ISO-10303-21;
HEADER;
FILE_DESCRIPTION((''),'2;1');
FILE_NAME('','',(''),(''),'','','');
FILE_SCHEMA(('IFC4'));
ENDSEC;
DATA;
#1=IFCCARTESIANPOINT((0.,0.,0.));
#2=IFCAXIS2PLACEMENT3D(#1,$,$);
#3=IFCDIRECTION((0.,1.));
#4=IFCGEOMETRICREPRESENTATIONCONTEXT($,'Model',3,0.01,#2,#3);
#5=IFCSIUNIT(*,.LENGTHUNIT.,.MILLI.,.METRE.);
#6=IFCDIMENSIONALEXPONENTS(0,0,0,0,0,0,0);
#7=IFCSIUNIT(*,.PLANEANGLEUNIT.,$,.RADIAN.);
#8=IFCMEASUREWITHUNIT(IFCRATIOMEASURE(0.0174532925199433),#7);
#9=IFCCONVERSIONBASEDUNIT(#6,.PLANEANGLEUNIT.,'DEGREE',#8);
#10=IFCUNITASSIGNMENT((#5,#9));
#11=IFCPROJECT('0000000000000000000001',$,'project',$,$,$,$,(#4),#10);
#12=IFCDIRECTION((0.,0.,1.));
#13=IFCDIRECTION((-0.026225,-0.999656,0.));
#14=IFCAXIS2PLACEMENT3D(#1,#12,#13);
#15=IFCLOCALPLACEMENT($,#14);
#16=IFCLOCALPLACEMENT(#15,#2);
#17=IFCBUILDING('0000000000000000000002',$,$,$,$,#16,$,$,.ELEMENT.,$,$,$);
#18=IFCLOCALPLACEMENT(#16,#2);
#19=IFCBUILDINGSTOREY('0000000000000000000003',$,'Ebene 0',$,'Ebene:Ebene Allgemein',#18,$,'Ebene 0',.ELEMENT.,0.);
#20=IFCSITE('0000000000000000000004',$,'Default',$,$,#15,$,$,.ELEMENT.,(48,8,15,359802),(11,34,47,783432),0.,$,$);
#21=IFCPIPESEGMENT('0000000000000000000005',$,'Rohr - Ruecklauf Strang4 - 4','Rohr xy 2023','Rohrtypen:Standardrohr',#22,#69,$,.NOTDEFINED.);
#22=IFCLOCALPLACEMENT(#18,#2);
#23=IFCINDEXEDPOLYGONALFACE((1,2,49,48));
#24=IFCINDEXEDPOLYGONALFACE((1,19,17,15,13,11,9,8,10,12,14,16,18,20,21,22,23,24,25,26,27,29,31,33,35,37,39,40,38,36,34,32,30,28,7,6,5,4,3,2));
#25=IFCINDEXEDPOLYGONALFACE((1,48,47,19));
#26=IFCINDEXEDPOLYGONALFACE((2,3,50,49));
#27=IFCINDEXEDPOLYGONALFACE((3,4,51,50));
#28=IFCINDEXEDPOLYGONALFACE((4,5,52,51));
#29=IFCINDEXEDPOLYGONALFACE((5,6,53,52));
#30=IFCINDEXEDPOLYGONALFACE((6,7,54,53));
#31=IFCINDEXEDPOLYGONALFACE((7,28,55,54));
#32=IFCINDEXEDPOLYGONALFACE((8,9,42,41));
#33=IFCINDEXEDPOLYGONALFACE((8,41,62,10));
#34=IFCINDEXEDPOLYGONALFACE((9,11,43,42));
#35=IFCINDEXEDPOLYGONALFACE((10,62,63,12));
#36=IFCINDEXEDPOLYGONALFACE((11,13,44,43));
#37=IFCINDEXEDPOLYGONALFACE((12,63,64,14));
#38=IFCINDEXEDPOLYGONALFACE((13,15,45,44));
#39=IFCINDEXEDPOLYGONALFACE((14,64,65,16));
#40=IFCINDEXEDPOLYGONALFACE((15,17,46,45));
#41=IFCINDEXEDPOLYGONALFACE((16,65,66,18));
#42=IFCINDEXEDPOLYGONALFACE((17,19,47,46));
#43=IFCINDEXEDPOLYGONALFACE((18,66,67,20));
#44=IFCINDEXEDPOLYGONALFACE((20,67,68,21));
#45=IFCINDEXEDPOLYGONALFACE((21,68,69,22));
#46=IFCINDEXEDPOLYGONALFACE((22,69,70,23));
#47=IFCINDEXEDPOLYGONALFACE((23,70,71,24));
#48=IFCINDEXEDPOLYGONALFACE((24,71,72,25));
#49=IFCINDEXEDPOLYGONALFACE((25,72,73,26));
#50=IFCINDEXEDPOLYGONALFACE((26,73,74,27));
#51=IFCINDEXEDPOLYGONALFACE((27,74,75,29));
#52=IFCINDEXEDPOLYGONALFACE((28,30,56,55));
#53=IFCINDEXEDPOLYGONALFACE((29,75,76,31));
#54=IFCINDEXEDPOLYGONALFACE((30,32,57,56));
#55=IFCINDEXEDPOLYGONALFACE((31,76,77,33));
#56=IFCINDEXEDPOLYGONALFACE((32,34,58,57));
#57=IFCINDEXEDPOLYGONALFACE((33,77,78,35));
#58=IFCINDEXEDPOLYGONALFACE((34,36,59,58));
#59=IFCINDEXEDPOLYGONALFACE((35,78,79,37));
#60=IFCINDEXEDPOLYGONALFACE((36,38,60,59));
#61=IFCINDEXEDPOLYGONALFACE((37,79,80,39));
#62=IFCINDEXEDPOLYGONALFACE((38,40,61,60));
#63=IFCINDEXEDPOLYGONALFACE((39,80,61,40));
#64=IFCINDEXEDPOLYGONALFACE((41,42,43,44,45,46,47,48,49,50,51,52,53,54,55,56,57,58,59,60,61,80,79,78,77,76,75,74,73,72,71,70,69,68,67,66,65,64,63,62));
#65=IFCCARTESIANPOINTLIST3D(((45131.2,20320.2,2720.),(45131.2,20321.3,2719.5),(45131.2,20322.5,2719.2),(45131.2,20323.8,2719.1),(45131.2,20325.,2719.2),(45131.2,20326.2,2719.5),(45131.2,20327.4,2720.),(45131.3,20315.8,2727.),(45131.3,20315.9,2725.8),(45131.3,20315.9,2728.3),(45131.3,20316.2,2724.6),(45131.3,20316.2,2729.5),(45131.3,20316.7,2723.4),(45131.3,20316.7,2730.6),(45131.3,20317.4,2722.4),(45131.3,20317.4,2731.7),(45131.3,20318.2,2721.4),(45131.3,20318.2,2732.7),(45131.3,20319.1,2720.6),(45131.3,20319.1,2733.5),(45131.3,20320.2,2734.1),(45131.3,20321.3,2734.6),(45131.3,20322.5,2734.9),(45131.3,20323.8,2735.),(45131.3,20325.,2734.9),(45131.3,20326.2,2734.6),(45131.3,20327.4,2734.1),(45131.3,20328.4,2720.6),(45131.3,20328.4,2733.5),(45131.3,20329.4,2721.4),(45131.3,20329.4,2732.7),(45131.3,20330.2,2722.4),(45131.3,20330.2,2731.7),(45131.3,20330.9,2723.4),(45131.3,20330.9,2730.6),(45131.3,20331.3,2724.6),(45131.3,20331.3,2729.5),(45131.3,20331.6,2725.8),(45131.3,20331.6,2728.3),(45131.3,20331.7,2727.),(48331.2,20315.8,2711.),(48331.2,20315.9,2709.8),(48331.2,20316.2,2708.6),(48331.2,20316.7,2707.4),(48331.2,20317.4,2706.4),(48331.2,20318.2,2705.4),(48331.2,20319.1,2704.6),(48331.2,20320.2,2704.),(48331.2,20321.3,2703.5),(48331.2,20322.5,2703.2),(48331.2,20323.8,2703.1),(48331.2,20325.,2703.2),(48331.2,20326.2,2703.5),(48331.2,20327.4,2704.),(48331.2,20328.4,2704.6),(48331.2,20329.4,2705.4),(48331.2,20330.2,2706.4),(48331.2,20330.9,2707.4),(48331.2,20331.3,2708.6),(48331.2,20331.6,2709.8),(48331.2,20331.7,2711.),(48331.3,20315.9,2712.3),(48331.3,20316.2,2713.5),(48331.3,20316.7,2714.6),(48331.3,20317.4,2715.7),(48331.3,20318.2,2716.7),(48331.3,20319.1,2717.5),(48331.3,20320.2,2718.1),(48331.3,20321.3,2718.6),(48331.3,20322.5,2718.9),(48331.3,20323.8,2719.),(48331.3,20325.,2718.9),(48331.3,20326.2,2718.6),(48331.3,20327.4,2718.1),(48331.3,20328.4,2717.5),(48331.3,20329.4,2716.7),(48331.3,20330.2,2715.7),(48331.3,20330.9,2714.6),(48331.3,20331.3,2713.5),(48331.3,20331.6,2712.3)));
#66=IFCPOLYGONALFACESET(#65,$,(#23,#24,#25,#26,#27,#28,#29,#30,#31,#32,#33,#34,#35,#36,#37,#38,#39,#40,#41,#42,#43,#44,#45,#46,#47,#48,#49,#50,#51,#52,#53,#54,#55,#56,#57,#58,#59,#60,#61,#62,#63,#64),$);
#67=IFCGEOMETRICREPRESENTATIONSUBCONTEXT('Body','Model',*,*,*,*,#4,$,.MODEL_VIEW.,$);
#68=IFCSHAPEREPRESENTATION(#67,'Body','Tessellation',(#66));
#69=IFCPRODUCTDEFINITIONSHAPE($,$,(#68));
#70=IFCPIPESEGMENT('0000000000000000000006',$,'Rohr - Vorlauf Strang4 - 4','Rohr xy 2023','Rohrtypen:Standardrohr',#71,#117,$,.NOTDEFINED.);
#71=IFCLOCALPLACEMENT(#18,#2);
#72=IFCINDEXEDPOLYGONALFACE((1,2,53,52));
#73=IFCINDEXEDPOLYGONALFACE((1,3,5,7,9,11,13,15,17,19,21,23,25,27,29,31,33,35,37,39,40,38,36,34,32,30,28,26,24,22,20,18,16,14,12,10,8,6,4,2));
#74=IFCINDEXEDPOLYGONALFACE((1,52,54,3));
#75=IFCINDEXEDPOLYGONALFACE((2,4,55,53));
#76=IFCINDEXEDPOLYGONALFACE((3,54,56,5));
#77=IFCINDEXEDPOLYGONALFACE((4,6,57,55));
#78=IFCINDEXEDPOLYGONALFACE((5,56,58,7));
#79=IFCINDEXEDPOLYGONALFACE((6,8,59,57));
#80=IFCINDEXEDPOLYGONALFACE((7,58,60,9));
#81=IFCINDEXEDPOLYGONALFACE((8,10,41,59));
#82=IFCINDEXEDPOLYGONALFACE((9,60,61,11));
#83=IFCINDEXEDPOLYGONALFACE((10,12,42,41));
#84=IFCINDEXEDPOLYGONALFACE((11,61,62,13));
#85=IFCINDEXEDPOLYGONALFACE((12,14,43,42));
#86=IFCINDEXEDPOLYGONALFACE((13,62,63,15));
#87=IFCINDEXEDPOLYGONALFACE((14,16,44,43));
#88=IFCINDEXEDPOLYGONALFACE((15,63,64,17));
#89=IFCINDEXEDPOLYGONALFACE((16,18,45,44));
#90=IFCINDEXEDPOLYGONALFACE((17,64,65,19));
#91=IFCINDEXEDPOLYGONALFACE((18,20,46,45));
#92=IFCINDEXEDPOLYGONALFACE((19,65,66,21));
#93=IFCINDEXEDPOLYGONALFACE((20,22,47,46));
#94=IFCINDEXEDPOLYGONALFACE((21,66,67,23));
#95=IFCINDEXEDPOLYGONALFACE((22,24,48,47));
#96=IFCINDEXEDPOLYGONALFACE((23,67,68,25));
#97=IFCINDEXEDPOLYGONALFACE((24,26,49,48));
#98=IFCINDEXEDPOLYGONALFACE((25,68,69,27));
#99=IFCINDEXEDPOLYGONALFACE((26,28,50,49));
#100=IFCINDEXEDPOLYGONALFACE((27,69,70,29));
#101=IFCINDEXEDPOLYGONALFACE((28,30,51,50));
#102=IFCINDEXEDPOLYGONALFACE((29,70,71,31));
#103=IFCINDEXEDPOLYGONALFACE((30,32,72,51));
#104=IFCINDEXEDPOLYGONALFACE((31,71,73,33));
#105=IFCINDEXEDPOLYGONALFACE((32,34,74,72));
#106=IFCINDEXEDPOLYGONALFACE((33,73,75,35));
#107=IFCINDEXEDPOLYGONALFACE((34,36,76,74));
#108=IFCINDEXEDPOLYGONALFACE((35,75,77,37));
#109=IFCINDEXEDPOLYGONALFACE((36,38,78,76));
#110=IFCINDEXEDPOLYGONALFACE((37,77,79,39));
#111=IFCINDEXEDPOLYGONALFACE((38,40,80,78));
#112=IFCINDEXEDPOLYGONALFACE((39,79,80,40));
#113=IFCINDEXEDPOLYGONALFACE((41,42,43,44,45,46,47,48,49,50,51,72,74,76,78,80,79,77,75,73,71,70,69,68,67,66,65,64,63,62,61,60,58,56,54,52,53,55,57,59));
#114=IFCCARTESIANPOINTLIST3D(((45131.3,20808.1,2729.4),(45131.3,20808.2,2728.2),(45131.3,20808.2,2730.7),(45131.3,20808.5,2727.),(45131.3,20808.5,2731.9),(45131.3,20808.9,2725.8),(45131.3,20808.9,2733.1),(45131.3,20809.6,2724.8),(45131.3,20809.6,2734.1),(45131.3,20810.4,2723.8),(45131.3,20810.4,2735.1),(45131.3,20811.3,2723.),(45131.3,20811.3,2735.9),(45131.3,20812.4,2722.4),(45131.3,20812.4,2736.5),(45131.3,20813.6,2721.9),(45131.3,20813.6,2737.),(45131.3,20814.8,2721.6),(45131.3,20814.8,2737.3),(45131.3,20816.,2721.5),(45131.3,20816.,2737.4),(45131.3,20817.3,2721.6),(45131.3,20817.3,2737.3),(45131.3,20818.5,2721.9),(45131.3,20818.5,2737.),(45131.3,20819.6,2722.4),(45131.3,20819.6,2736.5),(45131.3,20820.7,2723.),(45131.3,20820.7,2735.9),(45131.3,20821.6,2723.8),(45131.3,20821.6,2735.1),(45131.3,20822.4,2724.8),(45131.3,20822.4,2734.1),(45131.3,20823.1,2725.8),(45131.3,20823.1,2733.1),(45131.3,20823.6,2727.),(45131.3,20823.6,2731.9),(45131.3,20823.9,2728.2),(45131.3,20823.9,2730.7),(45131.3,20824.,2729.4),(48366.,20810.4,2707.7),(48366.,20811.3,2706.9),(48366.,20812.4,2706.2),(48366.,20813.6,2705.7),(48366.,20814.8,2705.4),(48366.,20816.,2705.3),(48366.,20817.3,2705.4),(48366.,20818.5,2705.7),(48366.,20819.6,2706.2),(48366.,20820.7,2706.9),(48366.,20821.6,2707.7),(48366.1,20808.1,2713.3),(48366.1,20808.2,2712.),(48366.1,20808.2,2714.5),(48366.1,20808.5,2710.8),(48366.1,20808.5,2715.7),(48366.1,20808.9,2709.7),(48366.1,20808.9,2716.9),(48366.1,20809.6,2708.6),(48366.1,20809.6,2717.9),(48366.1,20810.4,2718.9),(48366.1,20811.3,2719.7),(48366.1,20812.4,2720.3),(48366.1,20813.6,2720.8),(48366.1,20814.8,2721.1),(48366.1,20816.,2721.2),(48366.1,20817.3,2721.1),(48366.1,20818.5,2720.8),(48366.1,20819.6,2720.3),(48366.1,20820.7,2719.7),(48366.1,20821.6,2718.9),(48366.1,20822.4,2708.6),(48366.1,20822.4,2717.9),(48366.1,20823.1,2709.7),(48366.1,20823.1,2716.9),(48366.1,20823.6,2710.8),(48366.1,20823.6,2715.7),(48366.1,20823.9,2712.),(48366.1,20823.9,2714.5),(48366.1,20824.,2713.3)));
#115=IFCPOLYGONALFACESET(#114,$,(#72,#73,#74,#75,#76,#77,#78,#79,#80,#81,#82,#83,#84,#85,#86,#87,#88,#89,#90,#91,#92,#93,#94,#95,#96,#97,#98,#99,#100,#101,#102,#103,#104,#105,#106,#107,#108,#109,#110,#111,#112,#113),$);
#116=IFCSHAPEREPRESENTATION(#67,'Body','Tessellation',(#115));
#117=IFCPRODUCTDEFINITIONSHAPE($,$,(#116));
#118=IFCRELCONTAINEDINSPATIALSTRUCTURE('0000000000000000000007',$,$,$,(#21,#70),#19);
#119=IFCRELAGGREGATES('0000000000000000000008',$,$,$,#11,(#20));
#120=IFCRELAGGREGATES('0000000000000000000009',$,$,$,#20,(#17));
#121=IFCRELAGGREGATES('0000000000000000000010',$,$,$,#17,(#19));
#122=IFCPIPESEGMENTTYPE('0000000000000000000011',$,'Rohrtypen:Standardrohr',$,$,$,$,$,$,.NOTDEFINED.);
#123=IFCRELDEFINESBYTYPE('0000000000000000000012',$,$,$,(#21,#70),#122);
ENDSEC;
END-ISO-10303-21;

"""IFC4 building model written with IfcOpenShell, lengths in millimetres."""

from ifc_helpers import new_model, entity, si_unit, converted_unit, direction, frame, origin, place, context, subcontext, project, spatial, indexed_curve, outline, extrude, type_object, element, save


model = new_model("IFC4")

# Units and contexts
model_context = context("Model", 3, precision=0.01, world=origin(), true_north=direction((0.0, 1.0)))
body_context = subcontext(model_context, "Body", "Model", "MODEL_VIEW")
ifc_project = project(units=[si_unit("LENGTHUNIT", "METRE", prefix="MILLI"), converted_unit("PLANEANGLEUNIT", "DEGREE", entity("IfcRatioMeasure", 0.0174532925199433), si_unit("PLANEANGLEUNIT", "RADIAN"), dimensions=[0, 0, 0, 0, 0, 0, 0])], contexts=[model_context])

# Site, building, storey
site_placement = place(None, frame((0.0, 0.0, 0.0), z_axis=(0.0, 0.0, 1.0), x_axis=(-0.026225, -0.999656, 0.0)))
site = spatial("IfcSite", under=ifc_project, at=site_placement, Name="Default", CompositionType="ELEMENT", RefLatitude=(48, 8, 15, 359802), RefLongitude=(11, 34, 47, 783432), RefElevation=0.0)
building_placement = place(site_placement, origin())
building = spatial("IfcBuilding", under=site, at=building_placement, CompositionType="ELEMENT")
storey_placement = place(building_placement, origin())
storey = spatial("IfcBuildingStorey", under=building, at=storey_placement, Name="Ebene 0", ObjectType="Ebene:Ebene Allgemein", LongName="Ebene 0", CompositionType="ELEMENT", Elevation=0.0)

# Pipe segments
pipe_segment_type = type_object("IfcPipeSegmentType", Name="Rohrtypen:Standardrohr", PredefinedType="NOTDEFINED")
pipe_segment_1_placement = place(storey_placement, origin())
element("IfcPipeSegment", 1, at=pipe_segment_1_placement, inside=storey, type_object=pipe_segment_type, Name="Rohr - Ruecklauf Strang4 - 4", Description="Rohr xy 2023", ObjectType="Rohrtypen:Standardrohr", PredefinedType="NOTDEFINED", context=body_context, shape_type="SweptSolid", body=[
    extrude(outline(indexed_curve([(7.9, 0.0), (7.8, 1.2), (7.6, 2.5), (7.1, 3.6), (6.4, 4.7), (5.6, 5.6), (4.7, 6.4), (3.6, 7.1), (2.5, 7.6), (1.2, 7.8), (0.0, 7.9), (-1.2, 7.8), (-2.5, 7.6), (-3.6, 7.1), (-4.7, 6.4), (-5.6, 5.6), (-6.4, 4.7), (-7.1, 3.6), (-7.6, 2.5), (-7.8, 1.2), (-7.9, 0.0), (-7.8, -1.2), (-7.6, -2.5), (-7.1, -3.6), (-6.4, -4.7), (-5.6, -5.6), (-4.7, -6.4), (-3.6, -7.1), (-2.5, -7.6), (-1.2, -7.8), (0.0, -7.9), (1.2, -7.8), (2.5, -7.6), (3.6, -7.1), (4.7, -6.4), (5.6, -5.6), (6.4, -4.7), (7.1, -3.6), (7.6, -2.5), (7.8, -1.2), (7.9, 0.0)], self_intersect=False)), frame((48331.2, 20323.8, 2711.0), z_axis=(-0.999988, 0.0, 0.005), x_axis=(0.0, 1.0, 0.0)), (0.0, 0.0, 1.0), 3200.0),
])
pipe_segment_2_placement = place(storey_placement, origin())
element("IfcPipeSegment", 2, at=pipe_segment_2_placement, inside=storey, type_object=pipe_segment_type, Name="Rohr - Vorlauf Strang4 - 4", Description="Rohr xy 2023", ObjectType="Rohrtypen:Standardrohr", PredefinedType="NOTDEFINED", context=body_context, shape_type="SweptSolid", body=[
    extrude(outline(indexed_curve([(7.9, 0.0), (7.8, 1.2), (7.6, 2.5), (7.1, 3.6), (6.4, 4.7), (5.6, 5.6), (4.7, 6.4), (3.6, 7.1), (2.5, 7.6), (1.2, 7.8), (0.0, 7.9), (-1.2, 7.8), (-2.5, 7.6), (-3.6, 7.1), (-4.7, 6.4), (-5.6, 5.6), (-6.4, 4.7), (-7.1, 3.6), (-7.6, 2.5), (-7.8, 1.2), (-7.9, 0.0), (-7.8, -1.2), (-7.6, -2.5), (-7.1, -3.6), (-6.4, -4.7), (-5.6, -5.6), (-4.7, -6.4), (-3.6, -7.1), (-2.5, -7.6), (-1.2, -7.8), (0.0, -7.9), (1.2, -7.8), (2.5, -7.6), (3.6, -7.1), (4.7, -6.4), (5.6, -5.6), (6.4, -4.7), (7.1, -3.6), (7.6, -2.5), (7.8, -1.2), (7.9, 0.0)], self_intersect=False)), frame((48366.1, 20816.0, 2713.3), z_axis=(-0.999988, 0.0, 0.005), x_axis=(0.0, 1.0, 0.0)), (0.0, 0.0, 1.0), 3234.8),
])

save(model, "model.ifc")
